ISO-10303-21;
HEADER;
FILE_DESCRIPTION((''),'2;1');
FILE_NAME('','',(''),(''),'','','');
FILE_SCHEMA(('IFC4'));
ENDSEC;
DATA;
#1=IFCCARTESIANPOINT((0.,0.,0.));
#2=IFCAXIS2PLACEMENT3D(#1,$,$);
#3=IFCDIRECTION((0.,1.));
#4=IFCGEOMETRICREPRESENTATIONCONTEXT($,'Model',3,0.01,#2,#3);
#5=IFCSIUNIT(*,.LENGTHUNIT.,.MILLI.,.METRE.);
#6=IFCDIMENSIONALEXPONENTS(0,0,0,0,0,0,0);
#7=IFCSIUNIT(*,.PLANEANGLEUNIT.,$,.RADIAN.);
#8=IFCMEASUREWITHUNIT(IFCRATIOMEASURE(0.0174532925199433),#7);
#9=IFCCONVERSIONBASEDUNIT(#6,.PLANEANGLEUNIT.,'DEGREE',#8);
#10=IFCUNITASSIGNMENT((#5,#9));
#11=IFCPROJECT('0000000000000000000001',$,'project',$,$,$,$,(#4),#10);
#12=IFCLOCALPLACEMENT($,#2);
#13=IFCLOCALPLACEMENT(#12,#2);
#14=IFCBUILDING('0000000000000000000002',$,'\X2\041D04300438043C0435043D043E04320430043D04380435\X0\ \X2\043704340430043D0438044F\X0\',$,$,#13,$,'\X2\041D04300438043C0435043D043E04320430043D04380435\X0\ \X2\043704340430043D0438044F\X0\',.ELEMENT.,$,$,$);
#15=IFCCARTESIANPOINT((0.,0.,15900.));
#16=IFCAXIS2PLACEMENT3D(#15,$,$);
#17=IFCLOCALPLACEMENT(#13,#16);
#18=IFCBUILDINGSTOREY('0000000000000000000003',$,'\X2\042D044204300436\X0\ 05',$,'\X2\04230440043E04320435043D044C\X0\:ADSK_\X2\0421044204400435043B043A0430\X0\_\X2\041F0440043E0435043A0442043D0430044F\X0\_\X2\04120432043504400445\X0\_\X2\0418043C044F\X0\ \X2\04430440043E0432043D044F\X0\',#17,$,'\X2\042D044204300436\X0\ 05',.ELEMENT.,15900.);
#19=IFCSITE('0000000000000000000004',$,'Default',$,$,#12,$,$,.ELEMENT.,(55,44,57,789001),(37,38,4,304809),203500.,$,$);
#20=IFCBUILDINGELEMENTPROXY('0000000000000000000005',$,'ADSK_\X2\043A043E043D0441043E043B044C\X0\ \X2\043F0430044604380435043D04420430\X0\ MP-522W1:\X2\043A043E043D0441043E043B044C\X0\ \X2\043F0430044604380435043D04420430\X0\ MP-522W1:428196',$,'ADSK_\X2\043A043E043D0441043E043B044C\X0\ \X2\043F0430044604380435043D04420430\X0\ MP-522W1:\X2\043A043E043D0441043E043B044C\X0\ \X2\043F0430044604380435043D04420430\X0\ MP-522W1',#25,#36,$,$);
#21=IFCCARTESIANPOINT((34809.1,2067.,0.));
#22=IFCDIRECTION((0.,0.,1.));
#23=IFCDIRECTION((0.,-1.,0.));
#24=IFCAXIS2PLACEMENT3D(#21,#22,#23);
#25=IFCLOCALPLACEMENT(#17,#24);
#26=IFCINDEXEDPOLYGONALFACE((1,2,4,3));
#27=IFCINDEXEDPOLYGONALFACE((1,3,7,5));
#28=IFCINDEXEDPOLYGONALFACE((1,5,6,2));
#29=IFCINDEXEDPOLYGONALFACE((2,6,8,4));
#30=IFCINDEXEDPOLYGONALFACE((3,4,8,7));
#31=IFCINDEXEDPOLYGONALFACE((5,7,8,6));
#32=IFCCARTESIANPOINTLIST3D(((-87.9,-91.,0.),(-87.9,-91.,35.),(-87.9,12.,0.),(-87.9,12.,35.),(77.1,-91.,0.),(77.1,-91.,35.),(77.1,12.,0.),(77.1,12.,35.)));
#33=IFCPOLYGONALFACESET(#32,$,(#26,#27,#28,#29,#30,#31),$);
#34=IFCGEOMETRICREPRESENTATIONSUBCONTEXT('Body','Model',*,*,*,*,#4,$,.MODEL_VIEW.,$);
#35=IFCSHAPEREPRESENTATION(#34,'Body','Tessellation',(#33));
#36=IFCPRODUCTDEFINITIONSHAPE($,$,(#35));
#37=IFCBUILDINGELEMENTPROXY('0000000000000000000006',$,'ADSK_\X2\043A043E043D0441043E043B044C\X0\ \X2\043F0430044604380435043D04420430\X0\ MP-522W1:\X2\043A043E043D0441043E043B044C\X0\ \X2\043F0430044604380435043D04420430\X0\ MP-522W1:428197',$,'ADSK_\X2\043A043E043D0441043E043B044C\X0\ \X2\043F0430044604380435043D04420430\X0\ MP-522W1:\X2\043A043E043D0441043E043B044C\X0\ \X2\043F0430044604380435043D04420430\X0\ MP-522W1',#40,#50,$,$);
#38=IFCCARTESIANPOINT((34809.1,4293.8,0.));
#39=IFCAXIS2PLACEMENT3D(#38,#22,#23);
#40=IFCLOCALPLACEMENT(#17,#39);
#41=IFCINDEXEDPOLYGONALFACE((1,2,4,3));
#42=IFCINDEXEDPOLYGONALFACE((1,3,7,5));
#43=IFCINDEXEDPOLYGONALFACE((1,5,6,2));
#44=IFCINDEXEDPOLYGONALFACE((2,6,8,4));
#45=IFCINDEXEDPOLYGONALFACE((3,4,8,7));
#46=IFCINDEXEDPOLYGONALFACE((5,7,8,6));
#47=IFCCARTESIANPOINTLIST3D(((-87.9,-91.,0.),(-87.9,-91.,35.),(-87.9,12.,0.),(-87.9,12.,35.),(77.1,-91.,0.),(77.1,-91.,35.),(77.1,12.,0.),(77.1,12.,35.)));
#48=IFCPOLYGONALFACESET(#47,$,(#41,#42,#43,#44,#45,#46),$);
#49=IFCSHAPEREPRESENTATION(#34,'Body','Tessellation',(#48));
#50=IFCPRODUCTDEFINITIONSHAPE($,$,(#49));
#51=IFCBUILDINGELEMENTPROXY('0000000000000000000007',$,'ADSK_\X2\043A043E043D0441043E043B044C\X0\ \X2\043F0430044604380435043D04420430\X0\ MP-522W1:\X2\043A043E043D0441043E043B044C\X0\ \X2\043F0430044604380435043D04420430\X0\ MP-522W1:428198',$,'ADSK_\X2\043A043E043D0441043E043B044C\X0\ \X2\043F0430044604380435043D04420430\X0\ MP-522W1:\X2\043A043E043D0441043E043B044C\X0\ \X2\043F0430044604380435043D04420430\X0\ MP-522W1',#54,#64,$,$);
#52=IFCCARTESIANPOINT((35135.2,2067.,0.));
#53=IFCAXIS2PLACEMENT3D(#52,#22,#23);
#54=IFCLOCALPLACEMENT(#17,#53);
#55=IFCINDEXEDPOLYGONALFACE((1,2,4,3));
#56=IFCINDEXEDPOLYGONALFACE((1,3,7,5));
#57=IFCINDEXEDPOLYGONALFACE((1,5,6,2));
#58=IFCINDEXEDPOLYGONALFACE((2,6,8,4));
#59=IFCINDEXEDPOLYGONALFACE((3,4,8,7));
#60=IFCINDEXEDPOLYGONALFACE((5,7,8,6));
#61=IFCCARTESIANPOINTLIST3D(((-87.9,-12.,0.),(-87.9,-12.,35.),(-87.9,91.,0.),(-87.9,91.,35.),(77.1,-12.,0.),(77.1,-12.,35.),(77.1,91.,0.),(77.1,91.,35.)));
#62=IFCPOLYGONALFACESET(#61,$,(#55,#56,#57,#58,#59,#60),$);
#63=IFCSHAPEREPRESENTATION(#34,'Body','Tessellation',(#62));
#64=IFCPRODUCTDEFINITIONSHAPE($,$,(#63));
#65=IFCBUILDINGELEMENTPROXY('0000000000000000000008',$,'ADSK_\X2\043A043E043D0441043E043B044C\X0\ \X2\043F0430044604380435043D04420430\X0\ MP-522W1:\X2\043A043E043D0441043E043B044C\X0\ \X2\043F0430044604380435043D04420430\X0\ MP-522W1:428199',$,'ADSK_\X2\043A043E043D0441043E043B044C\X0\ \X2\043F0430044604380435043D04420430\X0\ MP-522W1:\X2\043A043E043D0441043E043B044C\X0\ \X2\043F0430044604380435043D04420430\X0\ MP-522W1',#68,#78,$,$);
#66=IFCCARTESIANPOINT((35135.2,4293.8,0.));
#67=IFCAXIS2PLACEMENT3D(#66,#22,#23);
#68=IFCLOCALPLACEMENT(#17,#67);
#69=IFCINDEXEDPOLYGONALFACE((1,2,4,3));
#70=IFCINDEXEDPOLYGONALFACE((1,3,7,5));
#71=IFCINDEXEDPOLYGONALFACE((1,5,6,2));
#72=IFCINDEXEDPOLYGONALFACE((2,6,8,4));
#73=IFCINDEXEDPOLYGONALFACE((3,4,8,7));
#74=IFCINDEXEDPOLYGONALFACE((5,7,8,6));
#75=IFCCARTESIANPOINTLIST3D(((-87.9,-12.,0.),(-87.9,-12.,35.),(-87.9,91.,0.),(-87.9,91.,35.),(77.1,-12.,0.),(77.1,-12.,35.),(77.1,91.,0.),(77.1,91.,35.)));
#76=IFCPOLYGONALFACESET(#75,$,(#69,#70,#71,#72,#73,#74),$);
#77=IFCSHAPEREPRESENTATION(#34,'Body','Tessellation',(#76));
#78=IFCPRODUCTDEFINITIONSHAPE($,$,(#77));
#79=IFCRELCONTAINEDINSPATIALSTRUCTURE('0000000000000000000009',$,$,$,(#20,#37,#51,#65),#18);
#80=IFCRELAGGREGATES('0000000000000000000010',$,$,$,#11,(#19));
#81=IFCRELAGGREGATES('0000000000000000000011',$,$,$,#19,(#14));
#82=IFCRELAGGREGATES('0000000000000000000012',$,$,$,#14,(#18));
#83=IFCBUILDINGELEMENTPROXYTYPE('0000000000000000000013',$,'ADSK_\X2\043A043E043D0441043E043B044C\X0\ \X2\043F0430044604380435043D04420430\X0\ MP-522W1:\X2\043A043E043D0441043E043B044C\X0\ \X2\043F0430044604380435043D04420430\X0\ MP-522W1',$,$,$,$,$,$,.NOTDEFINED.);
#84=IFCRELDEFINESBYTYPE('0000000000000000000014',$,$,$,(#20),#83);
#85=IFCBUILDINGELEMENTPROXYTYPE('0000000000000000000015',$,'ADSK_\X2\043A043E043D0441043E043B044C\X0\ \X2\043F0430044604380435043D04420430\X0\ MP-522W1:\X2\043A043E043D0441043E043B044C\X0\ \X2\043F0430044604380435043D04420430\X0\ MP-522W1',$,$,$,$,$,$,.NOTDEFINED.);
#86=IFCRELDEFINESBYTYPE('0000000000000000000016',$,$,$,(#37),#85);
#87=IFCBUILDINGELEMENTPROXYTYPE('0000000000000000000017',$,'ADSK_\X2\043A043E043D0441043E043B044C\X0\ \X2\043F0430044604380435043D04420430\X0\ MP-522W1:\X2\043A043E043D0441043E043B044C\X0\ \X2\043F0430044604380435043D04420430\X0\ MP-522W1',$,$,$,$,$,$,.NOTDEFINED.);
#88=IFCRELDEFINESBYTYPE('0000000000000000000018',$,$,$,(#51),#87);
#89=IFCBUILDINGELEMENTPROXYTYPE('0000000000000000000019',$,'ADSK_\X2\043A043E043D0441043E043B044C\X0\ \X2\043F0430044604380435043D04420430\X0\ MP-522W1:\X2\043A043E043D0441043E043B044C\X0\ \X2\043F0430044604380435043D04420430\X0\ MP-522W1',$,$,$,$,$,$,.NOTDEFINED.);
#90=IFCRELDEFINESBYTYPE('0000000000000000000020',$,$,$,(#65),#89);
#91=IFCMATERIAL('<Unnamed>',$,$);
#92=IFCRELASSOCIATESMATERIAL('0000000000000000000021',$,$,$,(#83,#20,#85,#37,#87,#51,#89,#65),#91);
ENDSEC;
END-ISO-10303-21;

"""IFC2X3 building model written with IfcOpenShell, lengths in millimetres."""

from ifc_helpers import new_model, entity, si_unit, converted_unit, direction, frame, origin, origin_2d_with_axis, place, context, subcontext, project, spatial, rectangle, extrude, source, transform, mapped, material, type_object, type_shapes, element, save


model = new_model("IFC2X3")

# Units and contexts
model_context = context("Model", 3, precision=0.01, world=origin(), true_north=direction((0.0, 1.0)))
body_context = subcontext(model_context, "Body", "Model", "MODEL_VIEW")
ifc_project = project(units=[si_unit("LENGTHUNIT", "METRE", prefix="MILLI"), converted_unit("PLANEANGLEUNIT", "DEGREE", entity("IfcRatioMeasure", 0.0174532925199433), si_unit("PLANEANGLEUNIT", "RADIAN"), dimensions=[0, 0, 0, 0, 0, 0, 0])], contexts=[model_context])

# Site, building, storey
site_placement = place(None, origin())
site = spatial("IfcSite", under=ifc_project, at=site_placement, Name="Default", CompositionType="ELEMENT", RefLatitude=(55, 44, 57, 789001), RefLongitude=(37, 38, 4, 304809), RefElevation=203500.0)
building_placement = place(site_placement, origin())
building = spatial("IfcBuilding", under=site, at=building_placement, Name="Наименование здания", LongName="Наименование здания", CompositionType="ELEMENT")
storey_placement = place(building_placement, frame((0.0, 0.0, 15900.0)))
storey = spatial("IfcBuildingStorey", under=building, at=storey_placement, Name="Этаж 05", ObjectType="Уровень:ADSK_Стрелка_Проектная_Вверх_Имя уровня", LongName="Этаж 05", CompositionType="ELEMENT", Elevation=15900.0)

# Building element proxies
ifc_material = material(Name="<Unnamed>")
building_element_proxy_type_1 = type_object("IfcBuildingElementProxyType", Name="ADSK_консоль пациента MP-522W1:консоль пациента MP-522W1", PredefinedType="NOTDEFINED", material=ifc_material)
shared_shape_1 = source(origin(), body_context, "Body", "SweptSolid", [
    extrude(rectangle(XDim=165.0, YDim=103.0, at=origin_2d_with_axis()), frame((-5.4, -39.5, 0.0), z_axis=(0.0, 0.0, 1.0), x_axis=(-1.0, 0.0, 0.0)), (0.0, 0.0, 1.0), 35.0),
])
type_shapes(building_element_proxy_type_1, [shared_shape_1])
proxy_1_placement = place(storey_placement, frame((34809.1, 2067.0, 0.0), z_axis=(0.0, 0.0, 1.0), x_axis=(0.0, -1.0, 0.0)))
element("IfcBuildingElementProxy", 1, at=proxy_1_placement, inside=storey, type_object=building_element_proxy_type_1, material=ifc_material, Name="ADSK_консоль пациента MP-522W1:консоль пациента MP-522W1:428196", ObjectType="ADSK_консоль пациента MP-522W1:консоль пациента MP-522W1", context=body_context, shape_type="MappedRepresentation", body=[
    mapped(shared_shape_1, transform((0.0, 0.0, 0.0), scale=1.0)),
])
building_element_proxy_type_2 = type_object("IfcBuildingElementProxyType", Name="ADSK_консоль пациента MP-522W1:консоль пациента MP-522W1", PredefinedType="NOTDEFINED", material=ifc_material)
type_shapes(building_element_proxy_type_2, [shared_shape_1])
proxy_2_placement = place(storey_placement, frame((34809.1, 4293.8, 0.0), z_axis=(0.0, 0.0, 1.0), x_axis=(0.0, -1.0, 0.0)))
element("IfcBuildingElementProxy", 2, at=proxy_2_placement, inside=storey, type_object=building_element_proxy_type_2, material=ifc_material, Name="ADSK_консоль пациента MP-522W1:консоль пациента MP-522W1:428197", ObjectType="ADSK_консоль пациента MP-522W1:консоль пациента MP-522W1", context=body_context, shape_type="MappedRepresentation", body=[
    mapped(shared_shape_1, transform((0.0, 0.0, 0.0), scale=1.0)),
])
building_element_proxy_type_3 = type_object("IfcBuildingElementProxyType", Name="ADSK_консоль пациента MP-522W1:консоль пациента MP-522W1", PredefinedType="NOTDEFINED", material=ifc_material)
shared_shape_2 = source(origin(), body_context, "Body", "SweptSolid", [
    extrude(rectangle(XDim=103.0, YDim=165.0, at=origin_2d_with_axis()), frame((-5.4, 39.5, 0.0), z_axis=(0.0, 0.0, 1.0), x_axis=(0.0, 1.0, 0.0)), (0.0, 0.0, 1.0), 35.0),
])
type_shapes(building_element_proxy_type_3, [shared_shape_2])
proxy_3_placement = place(storey_placement, frame((35135.2, 2067.0, 0.0), z_axis=(0.0, 0.0, 1.0), x_axis=(0.0, -1.0, 0.0)))
element("IfcBuildingElementProxy", 3, at=proxy_3_placement, inside=storey, type_object=building_element_proxy_type_3, material=ifc_material, Name="ADSK_консоль пациента MP-522W1:консоль пациента MP-522W1:428198", ObjectType="ADSK_консоль пациента MP-522W1:консоль пациента MP-522W1", context=body_context, shape_type="MappedRepresentation", body=[
    mapped(shared_shape_2, transform((0.0, 0.0, 0.0), scale=1.0)),
])
building_element_proxy_type_4 = type_object("IfcBuildingElementProxyType", Name="ADSK_консоль пациента MP-522W1:консоль пациента MP-522W1", PredefinedType="NOTDEFINED", material=ifc_material)
type_shapes(building_element_proxy_type_4, [shared_shape_2])
proxy_4_placement = place(storey_placement, frame((35135.2, 4293.8, 0.0), z_axis=(0.0, 0.0, 1.0), x_axis=(0.0, -1.0, 0.0)))
element("IfcBuildingElementProxy", 4, at=proxy_4_placement, inside=storey, type_object=building_element_proxy_type_4, material=ifc_material, Name="ADSK_консоль пациента MP-522W1:консоль пациента MP-522W1:428199", ObjectType="ADSK_консоль пациента MP-522W1:консоль пациента MP-522W1", context=body_context, shape_type="MappedRepresentation", body=[
    mapped(shared_shape_2, transform((0.0, 0.0, 0.0), scale=1.0)),
])

save(model, "model.ifc")
